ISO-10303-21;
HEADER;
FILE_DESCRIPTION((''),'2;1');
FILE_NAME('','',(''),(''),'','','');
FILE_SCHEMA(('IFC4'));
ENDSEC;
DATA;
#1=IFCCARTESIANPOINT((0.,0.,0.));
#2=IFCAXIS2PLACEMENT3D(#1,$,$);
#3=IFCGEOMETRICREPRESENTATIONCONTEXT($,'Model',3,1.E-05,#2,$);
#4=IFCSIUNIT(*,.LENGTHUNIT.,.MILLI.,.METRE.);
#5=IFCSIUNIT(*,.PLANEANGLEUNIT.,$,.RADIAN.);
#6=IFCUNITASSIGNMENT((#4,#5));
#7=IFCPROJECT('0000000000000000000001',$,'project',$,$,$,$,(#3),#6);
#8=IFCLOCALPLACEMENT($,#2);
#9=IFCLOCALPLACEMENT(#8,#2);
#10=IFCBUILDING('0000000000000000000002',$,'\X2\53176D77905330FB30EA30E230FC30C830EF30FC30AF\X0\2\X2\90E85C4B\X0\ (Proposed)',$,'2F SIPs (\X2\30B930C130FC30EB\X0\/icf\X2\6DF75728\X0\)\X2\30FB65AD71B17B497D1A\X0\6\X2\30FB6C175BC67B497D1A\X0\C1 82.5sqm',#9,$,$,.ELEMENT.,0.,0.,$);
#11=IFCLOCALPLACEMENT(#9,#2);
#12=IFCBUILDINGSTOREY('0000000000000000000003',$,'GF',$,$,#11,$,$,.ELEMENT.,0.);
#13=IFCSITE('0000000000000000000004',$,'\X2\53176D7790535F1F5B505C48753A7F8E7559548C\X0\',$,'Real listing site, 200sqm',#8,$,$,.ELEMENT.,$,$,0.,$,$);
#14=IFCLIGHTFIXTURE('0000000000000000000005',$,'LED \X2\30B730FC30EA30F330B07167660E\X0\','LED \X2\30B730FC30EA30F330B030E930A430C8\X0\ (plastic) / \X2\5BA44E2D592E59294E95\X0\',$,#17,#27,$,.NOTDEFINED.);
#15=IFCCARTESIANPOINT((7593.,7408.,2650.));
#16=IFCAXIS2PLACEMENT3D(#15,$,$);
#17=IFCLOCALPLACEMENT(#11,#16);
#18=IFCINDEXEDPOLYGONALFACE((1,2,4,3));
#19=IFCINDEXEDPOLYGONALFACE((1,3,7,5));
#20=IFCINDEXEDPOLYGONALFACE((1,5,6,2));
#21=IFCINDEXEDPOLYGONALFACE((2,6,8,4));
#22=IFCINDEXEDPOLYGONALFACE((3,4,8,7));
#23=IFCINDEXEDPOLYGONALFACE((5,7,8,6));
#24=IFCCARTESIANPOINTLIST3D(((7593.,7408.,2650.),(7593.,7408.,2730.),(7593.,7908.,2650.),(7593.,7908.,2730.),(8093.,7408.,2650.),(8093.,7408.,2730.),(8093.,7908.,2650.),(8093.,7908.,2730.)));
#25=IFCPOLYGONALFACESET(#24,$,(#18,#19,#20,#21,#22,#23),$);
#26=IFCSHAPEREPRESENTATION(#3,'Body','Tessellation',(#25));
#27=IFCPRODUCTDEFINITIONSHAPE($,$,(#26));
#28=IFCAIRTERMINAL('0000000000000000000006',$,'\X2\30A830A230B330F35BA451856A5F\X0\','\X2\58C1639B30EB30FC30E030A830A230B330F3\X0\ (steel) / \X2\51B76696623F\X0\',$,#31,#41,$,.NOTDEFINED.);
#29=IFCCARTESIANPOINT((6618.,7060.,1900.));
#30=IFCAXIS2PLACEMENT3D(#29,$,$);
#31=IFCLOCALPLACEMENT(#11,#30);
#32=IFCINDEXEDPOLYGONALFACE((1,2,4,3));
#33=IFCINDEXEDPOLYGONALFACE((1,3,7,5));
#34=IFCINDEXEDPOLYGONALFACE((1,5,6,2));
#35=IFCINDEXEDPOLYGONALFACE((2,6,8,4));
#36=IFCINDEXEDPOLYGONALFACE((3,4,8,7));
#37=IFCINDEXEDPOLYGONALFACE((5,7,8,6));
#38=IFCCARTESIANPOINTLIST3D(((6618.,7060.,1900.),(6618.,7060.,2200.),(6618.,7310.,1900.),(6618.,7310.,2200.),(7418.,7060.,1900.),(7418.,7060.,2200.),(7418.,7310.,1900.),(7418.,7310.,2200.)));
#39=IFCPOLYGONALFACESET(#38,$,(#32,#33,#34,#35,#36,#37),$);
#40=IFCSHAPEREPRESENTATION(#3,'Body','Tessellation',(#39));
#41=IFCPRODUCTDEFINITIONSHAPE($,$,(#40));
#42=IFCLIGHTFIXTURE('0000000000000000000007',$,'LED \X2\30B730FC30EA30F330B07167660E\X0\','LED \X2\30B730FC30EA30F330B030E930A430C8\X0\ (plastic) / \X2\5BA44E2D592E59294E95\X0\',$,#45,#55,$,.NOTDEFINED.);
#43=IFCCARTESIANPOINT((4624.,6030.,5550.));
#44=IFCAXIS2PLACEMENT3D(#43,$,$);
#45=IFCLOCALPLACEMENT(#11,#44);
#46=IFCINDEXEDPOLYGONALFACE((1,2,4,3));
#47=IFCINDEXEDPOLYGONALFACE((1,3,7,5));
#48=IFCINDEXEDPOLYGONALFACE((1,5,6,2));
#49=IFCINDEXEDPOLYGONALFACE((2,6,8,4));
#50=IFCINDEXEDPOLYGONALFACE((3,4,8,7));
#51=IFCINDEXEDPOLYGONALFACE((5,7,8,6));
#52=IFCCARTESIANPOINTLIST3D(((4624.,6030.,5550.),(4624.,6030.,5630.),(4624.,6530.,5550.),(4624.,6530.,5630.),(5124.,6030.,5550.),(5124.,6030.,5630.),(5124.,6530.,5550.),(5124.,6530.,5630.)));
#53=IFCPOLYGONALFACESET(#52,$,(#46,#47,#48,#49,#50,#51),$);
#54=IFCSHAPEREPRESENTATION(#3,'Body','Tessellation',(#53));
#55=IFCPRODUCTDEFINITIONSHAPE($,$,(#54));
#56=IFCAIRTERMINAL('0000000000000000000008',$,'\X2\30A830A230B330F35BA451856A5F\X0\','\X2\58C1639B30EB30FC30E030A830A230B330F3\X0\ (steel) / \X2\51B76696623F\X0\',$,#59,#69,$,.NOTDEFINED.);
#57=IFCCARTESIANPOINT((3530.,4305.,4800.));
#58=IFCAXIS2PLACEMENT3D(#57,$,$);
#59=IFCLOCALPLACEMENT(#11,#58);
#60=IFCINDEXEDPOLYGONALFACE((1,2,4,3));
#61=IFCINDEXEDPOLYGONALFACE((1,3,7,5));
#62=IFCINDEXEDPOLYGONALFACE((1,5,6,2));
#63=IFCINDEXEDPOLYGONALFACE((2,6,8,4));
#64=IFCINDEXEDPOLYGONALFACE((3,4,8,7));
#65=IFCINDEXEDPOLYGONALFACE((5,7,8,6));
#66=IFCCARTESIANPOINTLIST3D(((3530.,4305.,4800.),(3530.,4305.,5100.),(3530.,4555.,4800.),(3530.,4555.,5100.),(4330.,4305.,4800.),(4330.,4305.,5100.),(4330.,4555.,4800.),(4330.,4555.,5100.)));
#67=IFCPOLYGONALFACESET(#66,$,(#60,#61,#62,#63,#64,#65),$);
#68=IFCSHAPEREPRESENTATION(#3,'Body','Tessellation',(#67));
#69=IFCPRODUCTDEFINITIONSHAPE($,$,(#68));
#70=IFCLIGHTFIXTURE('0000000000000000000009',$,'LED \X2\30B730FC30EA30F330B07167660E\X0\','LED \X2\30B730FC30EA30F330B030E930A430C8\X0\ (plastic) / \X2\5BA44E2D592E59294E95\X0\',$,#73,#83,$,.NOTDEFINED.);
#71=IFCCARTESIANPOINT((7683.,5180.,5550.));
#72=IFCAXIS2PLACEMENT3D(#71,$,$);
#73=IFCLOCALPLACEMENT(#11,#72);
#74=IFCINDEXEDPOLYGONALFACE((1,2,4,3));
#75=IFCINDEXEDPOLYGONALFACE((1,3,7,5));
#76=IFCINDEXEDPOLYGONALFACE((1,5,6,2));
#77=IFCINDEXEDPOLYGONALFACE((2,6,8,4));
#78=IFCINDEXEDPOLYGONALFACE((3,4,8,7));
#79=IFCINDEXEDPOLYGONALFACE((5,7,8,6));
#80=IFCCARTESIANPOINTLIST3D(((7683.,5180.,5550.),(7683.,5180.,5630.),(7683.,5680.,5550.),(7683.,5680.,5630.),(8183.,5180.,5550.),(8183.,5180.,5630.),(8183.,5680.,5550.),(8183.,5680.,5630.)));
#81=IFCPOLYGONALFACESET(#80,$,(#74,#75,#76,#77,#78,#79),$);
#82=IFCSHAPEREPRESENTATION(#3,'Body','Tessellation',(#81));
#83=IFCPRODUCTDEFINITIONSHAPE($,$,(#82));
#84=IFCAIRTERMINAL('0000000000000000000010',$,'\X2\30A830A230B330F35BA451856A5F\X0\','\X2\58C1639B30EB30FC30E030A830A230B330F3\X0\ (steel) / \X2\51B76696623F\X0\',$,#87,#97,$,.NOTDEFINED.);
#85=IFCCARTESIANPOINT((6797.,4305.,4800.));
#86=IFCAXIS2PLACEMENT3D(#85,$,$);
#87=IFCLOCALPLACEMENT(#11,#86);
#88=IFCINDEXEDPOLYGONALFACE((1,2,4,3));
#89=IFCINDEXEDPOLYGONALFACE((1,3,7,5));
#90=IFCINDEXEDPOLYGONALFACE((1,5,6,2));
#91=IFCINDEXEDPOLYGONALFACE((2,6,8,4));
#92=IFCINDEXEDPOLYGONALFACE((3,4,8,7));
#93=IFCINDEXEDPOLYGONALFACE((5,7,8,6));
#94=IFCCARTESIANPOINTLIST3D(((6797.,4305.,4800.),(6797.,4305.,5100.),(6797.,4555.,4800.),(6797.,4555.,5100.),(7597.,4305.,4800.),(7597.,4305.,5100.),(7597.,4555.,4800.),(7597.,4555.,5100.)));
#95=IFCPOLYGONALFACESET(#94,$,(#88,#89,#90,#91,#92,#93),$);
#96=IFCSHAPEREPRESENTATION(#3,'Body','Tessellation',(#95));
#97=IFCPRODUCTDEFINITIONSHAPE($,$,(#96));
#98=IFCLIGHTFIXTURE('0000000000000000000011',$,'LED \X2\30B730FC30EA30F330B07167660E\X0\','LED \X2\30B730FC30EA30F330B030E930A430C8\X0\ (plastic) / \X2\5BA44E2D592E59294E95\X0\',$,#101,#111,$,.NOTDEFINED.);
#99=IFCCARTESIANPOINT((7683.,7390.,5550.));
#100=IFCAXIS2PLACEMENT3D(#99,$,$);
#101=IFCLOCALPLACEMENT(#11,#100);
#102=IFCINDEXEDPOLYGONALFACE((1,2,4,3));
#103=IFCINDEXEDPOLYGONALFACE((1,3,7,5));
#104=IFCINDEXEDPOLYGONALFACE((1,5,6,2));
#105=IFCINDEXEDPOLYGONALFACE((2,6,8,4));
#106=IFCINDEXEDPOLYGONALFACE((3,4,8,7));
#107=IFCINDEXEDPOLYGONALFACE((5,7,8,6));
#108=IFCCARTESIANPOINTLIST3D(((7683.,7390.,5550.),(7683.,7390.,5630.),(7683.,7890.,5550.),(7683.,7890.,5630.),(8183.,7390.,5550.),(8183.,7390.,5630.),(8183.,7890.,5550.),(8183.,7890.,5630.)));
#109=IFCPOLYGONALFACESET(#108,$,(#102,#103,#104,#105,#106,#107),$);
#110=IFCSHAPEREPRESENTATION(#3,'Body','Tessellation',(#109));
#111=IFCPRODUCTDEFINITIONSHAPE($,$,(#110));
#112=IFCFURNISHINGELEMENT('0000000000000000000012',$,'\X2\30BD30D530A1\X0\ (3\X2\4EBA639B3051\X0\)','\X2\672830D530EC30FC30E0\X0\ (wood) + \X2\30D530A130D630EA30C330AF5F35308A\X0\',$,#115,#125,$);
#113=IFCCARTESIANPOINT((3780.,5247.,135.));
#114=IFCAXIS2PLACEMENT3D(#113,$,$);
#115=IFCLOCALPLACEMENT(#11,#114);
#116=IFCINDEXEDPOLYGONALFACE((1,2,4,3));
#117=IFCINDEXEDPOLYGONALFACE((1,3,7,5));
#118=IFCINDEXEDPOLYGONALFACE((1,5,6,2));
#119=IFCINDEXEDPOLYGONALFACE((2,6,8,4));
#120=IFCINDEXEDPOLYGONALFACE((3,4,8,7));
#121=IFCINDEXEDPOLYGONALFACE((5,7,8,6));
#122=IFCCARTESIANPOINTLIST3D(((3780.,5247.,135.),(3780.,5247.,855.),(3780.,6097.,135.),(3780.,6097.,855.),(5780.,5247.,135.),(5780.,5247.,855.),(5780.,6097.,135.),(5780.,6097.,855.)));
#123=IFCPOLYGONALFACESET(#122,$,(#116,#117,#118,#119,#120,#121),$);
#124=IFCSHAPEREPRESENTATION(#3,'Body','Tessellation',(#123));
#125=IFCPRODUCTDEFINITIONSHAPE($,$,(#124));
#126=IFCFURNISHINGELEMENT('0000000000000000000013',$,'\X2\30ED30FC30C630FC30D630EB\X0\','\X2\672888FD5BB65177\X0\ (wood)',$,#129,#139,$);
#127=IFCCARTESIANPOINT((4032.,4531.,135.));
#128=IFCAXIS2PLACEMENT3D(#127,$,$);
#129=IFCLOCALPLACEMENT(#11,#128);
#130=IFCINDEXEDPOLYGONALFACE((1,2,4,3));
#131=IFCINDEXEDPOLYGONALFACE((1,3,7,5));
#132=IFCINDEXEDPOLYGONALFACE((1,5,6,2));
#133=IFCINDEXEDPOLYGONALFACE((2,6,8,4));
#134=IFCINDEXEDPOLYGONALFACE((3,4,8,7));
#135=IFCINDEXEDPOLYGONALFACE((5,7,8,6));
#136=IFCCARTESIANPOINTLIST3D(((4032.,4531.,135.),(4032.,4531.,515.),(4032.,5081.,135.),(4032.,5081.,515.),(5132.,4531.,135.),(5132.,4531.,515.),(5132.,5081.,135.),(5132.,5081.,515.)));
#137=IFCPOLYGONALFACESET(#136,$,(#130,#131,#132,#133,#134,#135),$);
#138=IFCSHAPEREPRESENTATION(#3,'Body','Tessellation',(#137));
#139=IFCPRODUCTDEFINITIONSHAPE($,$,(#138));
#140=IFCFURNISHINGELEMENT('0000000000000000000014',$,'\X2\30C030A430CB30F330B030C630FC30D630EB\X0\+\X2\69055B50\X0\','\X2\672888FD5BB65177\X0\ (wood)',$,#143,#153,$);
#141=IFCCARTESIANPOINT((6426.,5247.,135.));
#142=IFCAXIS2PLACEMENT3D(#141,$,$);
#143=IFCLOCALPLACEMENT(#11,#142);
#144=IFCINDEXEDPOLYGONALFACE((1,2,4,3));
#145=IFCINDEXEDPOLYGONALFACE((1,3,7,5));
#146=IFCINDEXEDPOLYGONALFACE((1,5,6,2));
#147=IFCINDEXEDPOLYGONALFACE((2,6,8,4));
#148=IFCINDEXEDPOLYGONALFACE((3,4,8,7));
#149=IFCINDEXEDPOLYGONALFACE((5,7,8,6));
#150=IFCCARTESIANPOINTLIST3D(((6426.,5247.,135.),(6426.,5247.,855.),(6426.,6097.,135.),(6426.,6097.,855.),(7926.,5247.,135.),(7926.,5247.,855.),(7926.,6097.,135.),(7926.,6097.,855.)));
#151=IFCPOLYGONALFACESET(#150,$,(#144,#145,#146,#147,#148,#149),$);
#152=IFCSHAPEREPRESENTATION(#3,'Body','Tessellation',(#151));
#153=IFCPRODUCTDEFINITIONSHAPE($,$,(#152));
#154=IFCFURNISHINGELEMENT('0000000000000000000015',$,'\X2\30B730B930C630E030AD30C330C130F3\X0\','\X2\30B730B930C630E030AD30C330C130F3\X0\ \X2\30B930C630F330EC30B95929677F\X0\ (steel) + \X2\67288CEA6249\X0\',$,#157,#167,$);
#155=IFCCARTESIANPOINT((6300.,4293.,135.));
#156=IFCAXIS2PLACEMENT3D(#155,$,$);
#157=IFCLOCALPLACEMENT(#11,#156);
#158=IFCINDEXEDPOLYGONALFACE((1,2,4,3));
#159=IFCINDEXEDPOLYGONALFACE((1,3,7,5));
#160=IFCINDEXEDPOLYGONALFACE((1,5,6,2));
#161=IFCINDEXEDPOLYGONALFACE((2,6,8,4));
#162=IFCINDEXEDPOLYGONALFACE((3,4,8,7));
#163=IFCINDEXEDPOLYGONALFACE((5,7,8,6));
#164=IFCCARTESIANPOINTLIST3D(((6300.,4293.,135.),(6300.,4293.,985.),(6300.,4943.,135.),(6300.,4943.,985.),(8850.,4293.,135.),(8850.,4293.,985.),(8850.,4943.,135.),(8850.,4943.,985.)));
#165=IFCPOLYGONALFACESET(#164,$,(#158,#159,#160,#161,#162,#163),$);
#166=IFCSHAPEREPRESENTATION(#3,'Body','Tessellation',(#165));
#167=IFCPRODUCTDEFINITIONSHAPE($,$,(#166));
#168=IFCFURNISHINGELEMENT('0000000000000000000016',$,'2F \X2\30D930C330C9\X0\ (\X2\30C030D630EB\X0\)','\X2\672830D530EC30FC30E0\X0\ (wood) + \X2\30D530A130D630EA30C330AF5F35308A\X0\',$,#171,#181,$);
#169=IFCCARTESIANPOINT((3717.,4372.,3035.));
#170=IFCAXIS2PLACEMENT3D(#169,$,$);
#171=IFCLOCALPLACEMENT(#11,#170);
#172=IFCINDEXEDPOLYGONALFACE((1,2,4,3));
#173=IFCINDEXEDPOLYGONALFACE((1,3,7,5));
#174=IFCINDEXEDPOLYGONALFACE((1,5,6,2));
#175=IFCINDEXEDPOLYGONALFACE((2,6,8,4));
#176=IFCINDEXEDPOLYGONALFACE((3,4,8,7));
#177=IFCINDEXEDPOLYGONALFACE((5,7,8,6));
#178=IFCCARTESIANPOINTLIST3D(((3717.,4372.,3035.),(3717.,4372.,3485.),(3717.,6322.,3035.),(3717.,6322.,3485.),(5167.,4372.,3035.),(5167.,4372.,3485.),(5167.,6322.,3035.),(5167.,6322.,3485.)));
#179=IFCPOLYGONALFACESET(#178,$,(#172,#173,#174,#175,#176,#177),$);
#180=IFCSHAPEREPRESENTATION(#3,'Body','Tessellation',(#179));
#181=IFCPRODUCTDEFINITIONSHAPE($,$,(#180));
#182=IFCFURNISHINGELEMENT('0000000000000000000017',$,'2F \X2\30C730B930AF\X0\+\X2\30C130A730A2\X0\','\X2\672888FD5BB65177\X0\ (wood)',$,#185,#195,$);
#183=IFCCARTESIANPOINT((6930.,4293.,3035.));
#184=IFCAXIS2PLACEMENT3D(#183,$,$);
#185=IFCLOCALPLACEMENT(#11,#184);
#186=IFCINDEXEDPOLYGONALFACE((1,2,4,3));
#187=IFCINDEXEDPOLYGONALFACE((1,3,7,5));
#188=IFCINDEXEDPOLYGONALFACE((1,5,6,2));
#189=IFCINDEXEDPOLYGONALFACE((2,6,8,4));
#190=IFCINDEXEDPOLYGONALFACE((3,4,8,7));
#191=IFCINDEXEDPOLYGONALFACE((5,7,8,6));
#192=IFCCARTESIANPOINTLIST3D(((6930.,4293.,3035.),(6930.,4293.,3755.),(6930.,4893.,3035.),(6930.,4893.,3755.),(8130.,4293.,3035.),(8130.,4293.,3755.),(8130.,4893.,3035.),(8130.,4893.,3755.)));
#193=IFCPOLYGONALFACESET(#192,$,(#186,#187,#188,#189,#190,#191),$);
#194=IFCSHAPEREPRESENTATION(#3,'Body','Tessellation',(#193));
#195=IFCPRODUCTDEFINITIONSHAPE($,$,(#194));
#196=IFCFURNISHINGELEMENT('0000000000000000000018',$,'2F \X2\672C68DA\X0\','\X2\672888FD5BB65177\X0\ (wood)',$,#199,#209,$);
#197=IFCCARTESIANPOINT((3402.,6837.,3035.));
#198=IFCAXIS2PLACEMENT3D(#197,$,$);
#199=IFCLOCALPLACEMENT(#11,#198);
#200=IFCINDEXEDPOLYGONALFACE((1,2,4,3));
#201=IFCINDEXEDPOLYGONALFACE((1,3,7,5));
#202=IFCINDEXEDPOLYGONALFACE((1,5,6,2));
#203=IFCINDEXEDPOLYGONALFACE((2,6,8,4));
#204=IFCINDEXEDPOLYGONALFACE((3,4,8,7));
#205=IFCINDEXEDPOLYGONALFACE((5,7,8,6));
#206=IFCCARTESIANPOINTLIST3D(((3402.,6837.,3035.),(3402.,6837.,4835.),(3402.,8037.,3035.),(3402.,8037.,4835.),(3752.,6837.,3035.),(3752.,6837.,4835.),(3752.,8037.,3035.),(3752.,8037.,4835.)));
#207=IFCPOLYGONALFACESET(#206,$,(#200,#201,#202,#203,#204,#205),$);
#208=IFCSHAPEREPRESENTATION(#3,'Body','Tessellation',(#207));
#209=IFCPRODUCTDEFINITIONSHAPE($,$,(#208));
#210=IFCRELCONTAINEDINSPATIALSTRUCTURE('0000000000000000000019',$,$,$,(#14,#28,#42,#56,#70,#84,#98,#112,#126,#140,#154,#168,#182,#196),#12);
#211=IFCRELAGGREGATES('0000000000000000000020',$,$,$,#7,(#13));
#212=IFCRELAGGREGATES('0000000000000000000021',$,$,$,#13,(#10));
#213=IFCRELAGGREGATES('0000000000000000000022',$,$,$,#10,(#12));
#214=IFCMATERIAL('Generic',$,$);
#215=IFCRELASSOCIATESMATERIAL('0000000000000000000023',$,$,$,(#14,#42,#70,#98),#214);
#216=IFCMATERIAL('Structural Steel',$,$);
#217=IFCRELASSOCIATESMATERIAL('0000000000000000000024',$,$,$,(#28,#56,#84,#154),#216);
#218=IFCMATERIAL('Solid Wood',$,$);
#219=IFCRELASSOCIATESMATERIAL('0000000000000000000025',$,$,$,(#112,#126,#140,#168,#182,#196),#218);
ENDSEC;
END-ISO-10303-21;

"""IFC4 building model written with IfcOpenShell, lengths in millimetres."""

from ifc_helpers import new_model, si_unit, frame, frame_2d, origin, place, context, project, spatial, rectangle, extrude, material, element, save


model = new_model("IFC4")

# Units and contexts
model_context = context("Model", 3, precision=1e-05, world=origin())
ifc_project = project(units=[si_unit("LENGTHUNIT", "METRE", prefix="MILLI"), si_unit("PLANEANGLEUNIT", "RADIAN")], contexts=[model_context])

# Site, building, storey
site_placement = place(None, origin())
site = spatial("IfcSite", under=ifc_project, at=site_placement, Name="北海道弟子屈町美留和", ObjectType="Real listing site, 200sqm", CompositionType="ELEMENT", RefElevation=0.0)
building_placement = place(site_placement, origin())
building = spatial("IfcBuilding", under=site, at=building_placement, Name="北海道・リモートワーク2部屋 (Proposed)", ObjectType="2F SIPs (スチール/icf混在)・断熱等級6・気密等級C1 82.5sqm", CompositionType="ELEMENT", ElevationOfRefHeight=0.0, ElevationOfTerrain=0.0)
storey_placement = place(building_placement, origin())
storey = spatial("IfcBuildingStorey", under=building, at=storey_placement, Name="GF", CompositionType="ELEMENT", Elevation=0.0)

# Shared definitions
ifc_material_1 = material(Name="Solid Wood")

# Shared definitions
ifc_material_2 = material(Name="Structural Steel")

# Shared definitions
ifc_material_3 = material(Name="Generic")

# Light fixture
light_fixture_1_placement = place(storey_placement, frame((7593.0, 7408.0, 2650.0)))
element("IfcLightFixture", 1, at=light_fixture_1_placement, inside=storey, material=ifc_material_3, Name="LED シーリング照明", Description="LED シーリングライト (plastic) / 室中央天井", PredefinedType="NOTDEFINED", context=model_context, shape_type="SweptSolid", body=[
    extrude(rectangle(XDim=500.0, YDim=500.0, at=frame_2d((250.0, 250.0))), frame((7593.0, 7408.0, 2650.0)), (0.0, 0.0, 1.0), 80.0),
])

# Air terminal
air_terminal_1_placement = place(storey_placement, frame((6618.0, 7060.0, 1900.0)))
element("IfcAirTerminal", 2, at=air_terminal_1_placement, inside=storey, material=ifc_material_2, Name="エアコン室内機", Description="壁掛ルームエアコン (steel) / 冷暖房", PredefinedType="NOTDEFINED", context=model_context, shape_type="SweptSolid", body=[
    extrude(rectangle(XDim=800.0, YDim=250.0, at=frame_2d((400.0, 125.0))), frame((6618.0, 7060.0, 1900.0)), (0.0, 0.0, 1.0), 300.0),
])

# Light fixture
light_fixture_2_placement = place(storey_placement, frame((4624.0, 6030.0, 5550.0)))
element("IfcLightFixture", 3, at=light_fixture_2_placement, inside=storey, material=ifc_material_3, Name="LED シーリング照明", Description="LED シーリングライト (plastic) / 室中央天井", PredefinedType="NOTDEFINED", context=model_context, shape_type="SweptSolid", body=[
    extrude(rectangle(XDim=500.0, YDim=500.0, at=frame_2d((250.0, 250.0))), frame((4624.0, 6030.0, 5550.0)), (0.0, 0.0, 1.0), 80.0),
])

# Air terminal
air_terminal_2_placement = place(storey_placement, frame((3530.0, 4305.0, 4800.0)))
element("IfcAirTerminal", 4, at=air_terminal_2_placement, inside=storey, material=ifc_material_2, Name="エアコン室内機", Description="壁掛ルームエアコン (steel) / 冷暖房", PredefinedType="NOTDEFINED", context=model_context, shape_type="SweptSolid", body=[
    extrude(rectangle(XDim=800.0, YDim=250.0, at=frame_2d((400.0, 125.0))), frame((3530.0, 4305.0, 4800.0)), (0.0, 0.0, 1.0), 300.0),
])

# Light fixture
light_fixture_3_placement = place(storey_placement, frame((7683.0, 5180.0, 5550.0)))
element("IfcLightFixture", 5, at=light_fixture_3_placement, inside=storey, material=ifc_material_3, Name="LED シーリング照明", Description="LED シーリングライト (plastic) / 室中央天井", PredefinedType="NOTDEFINED", context=model_context, shape_type="SweptSolid", body=[
    extrude(rectangle(XDim=500.0, YDim=500.0, at=frame_2d((250.0, 250.0))), frame((7683.0, 5180.0, 5550.0)), (0.0, 0.0, 1.0), 80.0),
])

# Air terminal
air_terminal_3_placement = place(storey_placement, frame((6797.0, 4305.0, 4800.0)))
element("IfcAirTerminal", 6, at=air_terminal_3_placement, inside=storey, material=ifc_material_2, Name="エアコン室内機", Description="壁掛ルームエアコン (steel) / 冷暖房", PredefinedType="NOTDEFINED", context=model_context, shape_type="SweptSolid", body=[
    extrude(rectangle(XDim=800.0, YDim=250.0, at=frame_2d((400.0, 125.0))), frame((6797.0, 4305.0, 4800.0)), (0.0, 0.0, 1.0), 300.0),
])

# Light fixture
light_fixture_4_placement = place(storey_placement, frame((7683.0, 7390.0, 5550.0)))
element("IfcLightFixture", 7, at=light_fixture_4_placement, inside=storey, material=ifc_material_3, Name="LED シーリング照明", Description="LED シーリングライト (plastic) / 室中央天井", PredefinedType="NOTDEFINED", context=model_context, shape_type="SweptSolid", body=[
    extrude(rectangle(XDim=500.0, YDim=500.0, at=frame_2d((250.0, 250.0))), frame((7683.0, 7390.0, 5550.0)), (0.0, 0.0, 1.0), 80.0),
])

# Furnishing elements
furnishing_1_placement = place(storey_placement, frame((3780.0, 5247.0, 135.0)))
element("IfcFurnishingElement", 8, at=furnishing_1_placement, inside=storey, material=ifc_material_1, Name="ソファ (3人掛け)", Description="木フレーム (wood) + ファブリック張り", context=model_context, shape_type="SweptSolid", body=[
    extrude(rectangle(XDim=2000.0, YDim=850.0, at=frame_2d((1000.0, 425.0))), frame((3780.0, 5247.0, 135.0)), (0.0, 0.0, 1.0), 720.0),
])
furnishing_2_placement = place(storey_placement, frame((4032.0, 4531.0, 135.0)))
element("IfcFurnishingElement", 9, at=furnishing_2_placement, inside=storey, material=ifc_material_1, Name="ローテーブル", Description="木製家具 (wood)", context=model_context, shape_type="SweptSolid", body=[
    extrude(rectangle(XDim=1100.0, YDim=550.0, at=frame_2d((550.0, 275.0))), frame((4032.0, 4531.0, 135.0)), (0.0, 0.0, 1.0), 380.0),
])
furnishing_3_placement = place(storey_placement, frame((6426.0, 5247.0, 135.0)))
element("IfcFurnishingElement", 10, at=furnishing_3_placement, inside=storey, material=ifc_material_1, Name="ダイニングテーブル+椅子", Description="木製家具 (wood)", context=model_context, shape_type="SweptSolid", body=[
    extrude(rectangle(XDim=1500.0, YDim=850.0, at=frame_2d((750.0, 425.0))), frame((6426.0, 5247.0, 135.0)), (0.0, 0.0, 1.0), 720.0),
])
furnishing_4_placement = place(storey_placement, frame((6300.0, 4293.0, 135.0)))
element("IfcFurnishingElement", 11, at=furnishing_4_placement, inside=storey, material=ifc_material_2, Name="システムキッチン", Description="システムキッチン ステンレス天板 (steel) + 木質扉", context=model_context, shape_type="SweptSolid", body=[
    extrude(rectangle(XDim=2550.0, YDim=650.0, at=frame_2d((1275.0, 325.0))), frame((6300.0, 4293.0, 135.0)), (0.0, 0.0, 1.0), 850.0),
])
furnishing_5_placement = place(storey_placement, frame((3717.0, 4372.0, 3035.0)))
element("IfcFurnishingElement", 12, at=furnishing_5_placement, inside=storey, material=ifc_material_1, Name="2F ベッド (ダブル)", Description="木フレーム (wood) + ファブリック張り", context=model_context, shape_type="SweptSolid", body=[
    extrude(rectangle(XDim=1450.0, YDim=1950.0, at=frame_2d((725.0, 975.0))), frame((3717.0, 4372.0, 3035.0)), (0.0, 0.0, 1.0), 450.0),
])
furnishing_6_placement = place(storey_placement, frame((6930.0, 4293.0, 3035.0)))
element("IfcFurnishingElement", 13, at=furnishing_6_placement, inside=storey, material=ifc_material_1, Name="2F デスク+チェア", Description="木製家具 (wood)", context=model_context, shape_type="SweptSolid", body=[
    extrude(rectangle(XDim=1200.0, YDim=600.0, at=frame_2d((600.0, 300.0))), frame((6930.0, 4293.0, 3035.0)), (0.0, 0.0, 1.0), 720.0),
])
furnishing_7_placement = place(storey_placement, frame((3402.0, 6837.0, 3035.0)))
element("IfcFurnishingElement", 14, at=furnishing_7_placement, inside=storey, material=ifc_material_1, Name="2F 本棚", Description="木製家具 (wood)", context=model_context, shape_type="SweptSolid", body=[
    extrude(rectangle(XDim=350.0, YDim=1200.0, at=frame_2d((175.0, 600.0))), frame((3402.0, 6837.0, 3035.0)), (0.0, 0.0, 1.0), 1800.0),
])

save(model, "model.ifc")
